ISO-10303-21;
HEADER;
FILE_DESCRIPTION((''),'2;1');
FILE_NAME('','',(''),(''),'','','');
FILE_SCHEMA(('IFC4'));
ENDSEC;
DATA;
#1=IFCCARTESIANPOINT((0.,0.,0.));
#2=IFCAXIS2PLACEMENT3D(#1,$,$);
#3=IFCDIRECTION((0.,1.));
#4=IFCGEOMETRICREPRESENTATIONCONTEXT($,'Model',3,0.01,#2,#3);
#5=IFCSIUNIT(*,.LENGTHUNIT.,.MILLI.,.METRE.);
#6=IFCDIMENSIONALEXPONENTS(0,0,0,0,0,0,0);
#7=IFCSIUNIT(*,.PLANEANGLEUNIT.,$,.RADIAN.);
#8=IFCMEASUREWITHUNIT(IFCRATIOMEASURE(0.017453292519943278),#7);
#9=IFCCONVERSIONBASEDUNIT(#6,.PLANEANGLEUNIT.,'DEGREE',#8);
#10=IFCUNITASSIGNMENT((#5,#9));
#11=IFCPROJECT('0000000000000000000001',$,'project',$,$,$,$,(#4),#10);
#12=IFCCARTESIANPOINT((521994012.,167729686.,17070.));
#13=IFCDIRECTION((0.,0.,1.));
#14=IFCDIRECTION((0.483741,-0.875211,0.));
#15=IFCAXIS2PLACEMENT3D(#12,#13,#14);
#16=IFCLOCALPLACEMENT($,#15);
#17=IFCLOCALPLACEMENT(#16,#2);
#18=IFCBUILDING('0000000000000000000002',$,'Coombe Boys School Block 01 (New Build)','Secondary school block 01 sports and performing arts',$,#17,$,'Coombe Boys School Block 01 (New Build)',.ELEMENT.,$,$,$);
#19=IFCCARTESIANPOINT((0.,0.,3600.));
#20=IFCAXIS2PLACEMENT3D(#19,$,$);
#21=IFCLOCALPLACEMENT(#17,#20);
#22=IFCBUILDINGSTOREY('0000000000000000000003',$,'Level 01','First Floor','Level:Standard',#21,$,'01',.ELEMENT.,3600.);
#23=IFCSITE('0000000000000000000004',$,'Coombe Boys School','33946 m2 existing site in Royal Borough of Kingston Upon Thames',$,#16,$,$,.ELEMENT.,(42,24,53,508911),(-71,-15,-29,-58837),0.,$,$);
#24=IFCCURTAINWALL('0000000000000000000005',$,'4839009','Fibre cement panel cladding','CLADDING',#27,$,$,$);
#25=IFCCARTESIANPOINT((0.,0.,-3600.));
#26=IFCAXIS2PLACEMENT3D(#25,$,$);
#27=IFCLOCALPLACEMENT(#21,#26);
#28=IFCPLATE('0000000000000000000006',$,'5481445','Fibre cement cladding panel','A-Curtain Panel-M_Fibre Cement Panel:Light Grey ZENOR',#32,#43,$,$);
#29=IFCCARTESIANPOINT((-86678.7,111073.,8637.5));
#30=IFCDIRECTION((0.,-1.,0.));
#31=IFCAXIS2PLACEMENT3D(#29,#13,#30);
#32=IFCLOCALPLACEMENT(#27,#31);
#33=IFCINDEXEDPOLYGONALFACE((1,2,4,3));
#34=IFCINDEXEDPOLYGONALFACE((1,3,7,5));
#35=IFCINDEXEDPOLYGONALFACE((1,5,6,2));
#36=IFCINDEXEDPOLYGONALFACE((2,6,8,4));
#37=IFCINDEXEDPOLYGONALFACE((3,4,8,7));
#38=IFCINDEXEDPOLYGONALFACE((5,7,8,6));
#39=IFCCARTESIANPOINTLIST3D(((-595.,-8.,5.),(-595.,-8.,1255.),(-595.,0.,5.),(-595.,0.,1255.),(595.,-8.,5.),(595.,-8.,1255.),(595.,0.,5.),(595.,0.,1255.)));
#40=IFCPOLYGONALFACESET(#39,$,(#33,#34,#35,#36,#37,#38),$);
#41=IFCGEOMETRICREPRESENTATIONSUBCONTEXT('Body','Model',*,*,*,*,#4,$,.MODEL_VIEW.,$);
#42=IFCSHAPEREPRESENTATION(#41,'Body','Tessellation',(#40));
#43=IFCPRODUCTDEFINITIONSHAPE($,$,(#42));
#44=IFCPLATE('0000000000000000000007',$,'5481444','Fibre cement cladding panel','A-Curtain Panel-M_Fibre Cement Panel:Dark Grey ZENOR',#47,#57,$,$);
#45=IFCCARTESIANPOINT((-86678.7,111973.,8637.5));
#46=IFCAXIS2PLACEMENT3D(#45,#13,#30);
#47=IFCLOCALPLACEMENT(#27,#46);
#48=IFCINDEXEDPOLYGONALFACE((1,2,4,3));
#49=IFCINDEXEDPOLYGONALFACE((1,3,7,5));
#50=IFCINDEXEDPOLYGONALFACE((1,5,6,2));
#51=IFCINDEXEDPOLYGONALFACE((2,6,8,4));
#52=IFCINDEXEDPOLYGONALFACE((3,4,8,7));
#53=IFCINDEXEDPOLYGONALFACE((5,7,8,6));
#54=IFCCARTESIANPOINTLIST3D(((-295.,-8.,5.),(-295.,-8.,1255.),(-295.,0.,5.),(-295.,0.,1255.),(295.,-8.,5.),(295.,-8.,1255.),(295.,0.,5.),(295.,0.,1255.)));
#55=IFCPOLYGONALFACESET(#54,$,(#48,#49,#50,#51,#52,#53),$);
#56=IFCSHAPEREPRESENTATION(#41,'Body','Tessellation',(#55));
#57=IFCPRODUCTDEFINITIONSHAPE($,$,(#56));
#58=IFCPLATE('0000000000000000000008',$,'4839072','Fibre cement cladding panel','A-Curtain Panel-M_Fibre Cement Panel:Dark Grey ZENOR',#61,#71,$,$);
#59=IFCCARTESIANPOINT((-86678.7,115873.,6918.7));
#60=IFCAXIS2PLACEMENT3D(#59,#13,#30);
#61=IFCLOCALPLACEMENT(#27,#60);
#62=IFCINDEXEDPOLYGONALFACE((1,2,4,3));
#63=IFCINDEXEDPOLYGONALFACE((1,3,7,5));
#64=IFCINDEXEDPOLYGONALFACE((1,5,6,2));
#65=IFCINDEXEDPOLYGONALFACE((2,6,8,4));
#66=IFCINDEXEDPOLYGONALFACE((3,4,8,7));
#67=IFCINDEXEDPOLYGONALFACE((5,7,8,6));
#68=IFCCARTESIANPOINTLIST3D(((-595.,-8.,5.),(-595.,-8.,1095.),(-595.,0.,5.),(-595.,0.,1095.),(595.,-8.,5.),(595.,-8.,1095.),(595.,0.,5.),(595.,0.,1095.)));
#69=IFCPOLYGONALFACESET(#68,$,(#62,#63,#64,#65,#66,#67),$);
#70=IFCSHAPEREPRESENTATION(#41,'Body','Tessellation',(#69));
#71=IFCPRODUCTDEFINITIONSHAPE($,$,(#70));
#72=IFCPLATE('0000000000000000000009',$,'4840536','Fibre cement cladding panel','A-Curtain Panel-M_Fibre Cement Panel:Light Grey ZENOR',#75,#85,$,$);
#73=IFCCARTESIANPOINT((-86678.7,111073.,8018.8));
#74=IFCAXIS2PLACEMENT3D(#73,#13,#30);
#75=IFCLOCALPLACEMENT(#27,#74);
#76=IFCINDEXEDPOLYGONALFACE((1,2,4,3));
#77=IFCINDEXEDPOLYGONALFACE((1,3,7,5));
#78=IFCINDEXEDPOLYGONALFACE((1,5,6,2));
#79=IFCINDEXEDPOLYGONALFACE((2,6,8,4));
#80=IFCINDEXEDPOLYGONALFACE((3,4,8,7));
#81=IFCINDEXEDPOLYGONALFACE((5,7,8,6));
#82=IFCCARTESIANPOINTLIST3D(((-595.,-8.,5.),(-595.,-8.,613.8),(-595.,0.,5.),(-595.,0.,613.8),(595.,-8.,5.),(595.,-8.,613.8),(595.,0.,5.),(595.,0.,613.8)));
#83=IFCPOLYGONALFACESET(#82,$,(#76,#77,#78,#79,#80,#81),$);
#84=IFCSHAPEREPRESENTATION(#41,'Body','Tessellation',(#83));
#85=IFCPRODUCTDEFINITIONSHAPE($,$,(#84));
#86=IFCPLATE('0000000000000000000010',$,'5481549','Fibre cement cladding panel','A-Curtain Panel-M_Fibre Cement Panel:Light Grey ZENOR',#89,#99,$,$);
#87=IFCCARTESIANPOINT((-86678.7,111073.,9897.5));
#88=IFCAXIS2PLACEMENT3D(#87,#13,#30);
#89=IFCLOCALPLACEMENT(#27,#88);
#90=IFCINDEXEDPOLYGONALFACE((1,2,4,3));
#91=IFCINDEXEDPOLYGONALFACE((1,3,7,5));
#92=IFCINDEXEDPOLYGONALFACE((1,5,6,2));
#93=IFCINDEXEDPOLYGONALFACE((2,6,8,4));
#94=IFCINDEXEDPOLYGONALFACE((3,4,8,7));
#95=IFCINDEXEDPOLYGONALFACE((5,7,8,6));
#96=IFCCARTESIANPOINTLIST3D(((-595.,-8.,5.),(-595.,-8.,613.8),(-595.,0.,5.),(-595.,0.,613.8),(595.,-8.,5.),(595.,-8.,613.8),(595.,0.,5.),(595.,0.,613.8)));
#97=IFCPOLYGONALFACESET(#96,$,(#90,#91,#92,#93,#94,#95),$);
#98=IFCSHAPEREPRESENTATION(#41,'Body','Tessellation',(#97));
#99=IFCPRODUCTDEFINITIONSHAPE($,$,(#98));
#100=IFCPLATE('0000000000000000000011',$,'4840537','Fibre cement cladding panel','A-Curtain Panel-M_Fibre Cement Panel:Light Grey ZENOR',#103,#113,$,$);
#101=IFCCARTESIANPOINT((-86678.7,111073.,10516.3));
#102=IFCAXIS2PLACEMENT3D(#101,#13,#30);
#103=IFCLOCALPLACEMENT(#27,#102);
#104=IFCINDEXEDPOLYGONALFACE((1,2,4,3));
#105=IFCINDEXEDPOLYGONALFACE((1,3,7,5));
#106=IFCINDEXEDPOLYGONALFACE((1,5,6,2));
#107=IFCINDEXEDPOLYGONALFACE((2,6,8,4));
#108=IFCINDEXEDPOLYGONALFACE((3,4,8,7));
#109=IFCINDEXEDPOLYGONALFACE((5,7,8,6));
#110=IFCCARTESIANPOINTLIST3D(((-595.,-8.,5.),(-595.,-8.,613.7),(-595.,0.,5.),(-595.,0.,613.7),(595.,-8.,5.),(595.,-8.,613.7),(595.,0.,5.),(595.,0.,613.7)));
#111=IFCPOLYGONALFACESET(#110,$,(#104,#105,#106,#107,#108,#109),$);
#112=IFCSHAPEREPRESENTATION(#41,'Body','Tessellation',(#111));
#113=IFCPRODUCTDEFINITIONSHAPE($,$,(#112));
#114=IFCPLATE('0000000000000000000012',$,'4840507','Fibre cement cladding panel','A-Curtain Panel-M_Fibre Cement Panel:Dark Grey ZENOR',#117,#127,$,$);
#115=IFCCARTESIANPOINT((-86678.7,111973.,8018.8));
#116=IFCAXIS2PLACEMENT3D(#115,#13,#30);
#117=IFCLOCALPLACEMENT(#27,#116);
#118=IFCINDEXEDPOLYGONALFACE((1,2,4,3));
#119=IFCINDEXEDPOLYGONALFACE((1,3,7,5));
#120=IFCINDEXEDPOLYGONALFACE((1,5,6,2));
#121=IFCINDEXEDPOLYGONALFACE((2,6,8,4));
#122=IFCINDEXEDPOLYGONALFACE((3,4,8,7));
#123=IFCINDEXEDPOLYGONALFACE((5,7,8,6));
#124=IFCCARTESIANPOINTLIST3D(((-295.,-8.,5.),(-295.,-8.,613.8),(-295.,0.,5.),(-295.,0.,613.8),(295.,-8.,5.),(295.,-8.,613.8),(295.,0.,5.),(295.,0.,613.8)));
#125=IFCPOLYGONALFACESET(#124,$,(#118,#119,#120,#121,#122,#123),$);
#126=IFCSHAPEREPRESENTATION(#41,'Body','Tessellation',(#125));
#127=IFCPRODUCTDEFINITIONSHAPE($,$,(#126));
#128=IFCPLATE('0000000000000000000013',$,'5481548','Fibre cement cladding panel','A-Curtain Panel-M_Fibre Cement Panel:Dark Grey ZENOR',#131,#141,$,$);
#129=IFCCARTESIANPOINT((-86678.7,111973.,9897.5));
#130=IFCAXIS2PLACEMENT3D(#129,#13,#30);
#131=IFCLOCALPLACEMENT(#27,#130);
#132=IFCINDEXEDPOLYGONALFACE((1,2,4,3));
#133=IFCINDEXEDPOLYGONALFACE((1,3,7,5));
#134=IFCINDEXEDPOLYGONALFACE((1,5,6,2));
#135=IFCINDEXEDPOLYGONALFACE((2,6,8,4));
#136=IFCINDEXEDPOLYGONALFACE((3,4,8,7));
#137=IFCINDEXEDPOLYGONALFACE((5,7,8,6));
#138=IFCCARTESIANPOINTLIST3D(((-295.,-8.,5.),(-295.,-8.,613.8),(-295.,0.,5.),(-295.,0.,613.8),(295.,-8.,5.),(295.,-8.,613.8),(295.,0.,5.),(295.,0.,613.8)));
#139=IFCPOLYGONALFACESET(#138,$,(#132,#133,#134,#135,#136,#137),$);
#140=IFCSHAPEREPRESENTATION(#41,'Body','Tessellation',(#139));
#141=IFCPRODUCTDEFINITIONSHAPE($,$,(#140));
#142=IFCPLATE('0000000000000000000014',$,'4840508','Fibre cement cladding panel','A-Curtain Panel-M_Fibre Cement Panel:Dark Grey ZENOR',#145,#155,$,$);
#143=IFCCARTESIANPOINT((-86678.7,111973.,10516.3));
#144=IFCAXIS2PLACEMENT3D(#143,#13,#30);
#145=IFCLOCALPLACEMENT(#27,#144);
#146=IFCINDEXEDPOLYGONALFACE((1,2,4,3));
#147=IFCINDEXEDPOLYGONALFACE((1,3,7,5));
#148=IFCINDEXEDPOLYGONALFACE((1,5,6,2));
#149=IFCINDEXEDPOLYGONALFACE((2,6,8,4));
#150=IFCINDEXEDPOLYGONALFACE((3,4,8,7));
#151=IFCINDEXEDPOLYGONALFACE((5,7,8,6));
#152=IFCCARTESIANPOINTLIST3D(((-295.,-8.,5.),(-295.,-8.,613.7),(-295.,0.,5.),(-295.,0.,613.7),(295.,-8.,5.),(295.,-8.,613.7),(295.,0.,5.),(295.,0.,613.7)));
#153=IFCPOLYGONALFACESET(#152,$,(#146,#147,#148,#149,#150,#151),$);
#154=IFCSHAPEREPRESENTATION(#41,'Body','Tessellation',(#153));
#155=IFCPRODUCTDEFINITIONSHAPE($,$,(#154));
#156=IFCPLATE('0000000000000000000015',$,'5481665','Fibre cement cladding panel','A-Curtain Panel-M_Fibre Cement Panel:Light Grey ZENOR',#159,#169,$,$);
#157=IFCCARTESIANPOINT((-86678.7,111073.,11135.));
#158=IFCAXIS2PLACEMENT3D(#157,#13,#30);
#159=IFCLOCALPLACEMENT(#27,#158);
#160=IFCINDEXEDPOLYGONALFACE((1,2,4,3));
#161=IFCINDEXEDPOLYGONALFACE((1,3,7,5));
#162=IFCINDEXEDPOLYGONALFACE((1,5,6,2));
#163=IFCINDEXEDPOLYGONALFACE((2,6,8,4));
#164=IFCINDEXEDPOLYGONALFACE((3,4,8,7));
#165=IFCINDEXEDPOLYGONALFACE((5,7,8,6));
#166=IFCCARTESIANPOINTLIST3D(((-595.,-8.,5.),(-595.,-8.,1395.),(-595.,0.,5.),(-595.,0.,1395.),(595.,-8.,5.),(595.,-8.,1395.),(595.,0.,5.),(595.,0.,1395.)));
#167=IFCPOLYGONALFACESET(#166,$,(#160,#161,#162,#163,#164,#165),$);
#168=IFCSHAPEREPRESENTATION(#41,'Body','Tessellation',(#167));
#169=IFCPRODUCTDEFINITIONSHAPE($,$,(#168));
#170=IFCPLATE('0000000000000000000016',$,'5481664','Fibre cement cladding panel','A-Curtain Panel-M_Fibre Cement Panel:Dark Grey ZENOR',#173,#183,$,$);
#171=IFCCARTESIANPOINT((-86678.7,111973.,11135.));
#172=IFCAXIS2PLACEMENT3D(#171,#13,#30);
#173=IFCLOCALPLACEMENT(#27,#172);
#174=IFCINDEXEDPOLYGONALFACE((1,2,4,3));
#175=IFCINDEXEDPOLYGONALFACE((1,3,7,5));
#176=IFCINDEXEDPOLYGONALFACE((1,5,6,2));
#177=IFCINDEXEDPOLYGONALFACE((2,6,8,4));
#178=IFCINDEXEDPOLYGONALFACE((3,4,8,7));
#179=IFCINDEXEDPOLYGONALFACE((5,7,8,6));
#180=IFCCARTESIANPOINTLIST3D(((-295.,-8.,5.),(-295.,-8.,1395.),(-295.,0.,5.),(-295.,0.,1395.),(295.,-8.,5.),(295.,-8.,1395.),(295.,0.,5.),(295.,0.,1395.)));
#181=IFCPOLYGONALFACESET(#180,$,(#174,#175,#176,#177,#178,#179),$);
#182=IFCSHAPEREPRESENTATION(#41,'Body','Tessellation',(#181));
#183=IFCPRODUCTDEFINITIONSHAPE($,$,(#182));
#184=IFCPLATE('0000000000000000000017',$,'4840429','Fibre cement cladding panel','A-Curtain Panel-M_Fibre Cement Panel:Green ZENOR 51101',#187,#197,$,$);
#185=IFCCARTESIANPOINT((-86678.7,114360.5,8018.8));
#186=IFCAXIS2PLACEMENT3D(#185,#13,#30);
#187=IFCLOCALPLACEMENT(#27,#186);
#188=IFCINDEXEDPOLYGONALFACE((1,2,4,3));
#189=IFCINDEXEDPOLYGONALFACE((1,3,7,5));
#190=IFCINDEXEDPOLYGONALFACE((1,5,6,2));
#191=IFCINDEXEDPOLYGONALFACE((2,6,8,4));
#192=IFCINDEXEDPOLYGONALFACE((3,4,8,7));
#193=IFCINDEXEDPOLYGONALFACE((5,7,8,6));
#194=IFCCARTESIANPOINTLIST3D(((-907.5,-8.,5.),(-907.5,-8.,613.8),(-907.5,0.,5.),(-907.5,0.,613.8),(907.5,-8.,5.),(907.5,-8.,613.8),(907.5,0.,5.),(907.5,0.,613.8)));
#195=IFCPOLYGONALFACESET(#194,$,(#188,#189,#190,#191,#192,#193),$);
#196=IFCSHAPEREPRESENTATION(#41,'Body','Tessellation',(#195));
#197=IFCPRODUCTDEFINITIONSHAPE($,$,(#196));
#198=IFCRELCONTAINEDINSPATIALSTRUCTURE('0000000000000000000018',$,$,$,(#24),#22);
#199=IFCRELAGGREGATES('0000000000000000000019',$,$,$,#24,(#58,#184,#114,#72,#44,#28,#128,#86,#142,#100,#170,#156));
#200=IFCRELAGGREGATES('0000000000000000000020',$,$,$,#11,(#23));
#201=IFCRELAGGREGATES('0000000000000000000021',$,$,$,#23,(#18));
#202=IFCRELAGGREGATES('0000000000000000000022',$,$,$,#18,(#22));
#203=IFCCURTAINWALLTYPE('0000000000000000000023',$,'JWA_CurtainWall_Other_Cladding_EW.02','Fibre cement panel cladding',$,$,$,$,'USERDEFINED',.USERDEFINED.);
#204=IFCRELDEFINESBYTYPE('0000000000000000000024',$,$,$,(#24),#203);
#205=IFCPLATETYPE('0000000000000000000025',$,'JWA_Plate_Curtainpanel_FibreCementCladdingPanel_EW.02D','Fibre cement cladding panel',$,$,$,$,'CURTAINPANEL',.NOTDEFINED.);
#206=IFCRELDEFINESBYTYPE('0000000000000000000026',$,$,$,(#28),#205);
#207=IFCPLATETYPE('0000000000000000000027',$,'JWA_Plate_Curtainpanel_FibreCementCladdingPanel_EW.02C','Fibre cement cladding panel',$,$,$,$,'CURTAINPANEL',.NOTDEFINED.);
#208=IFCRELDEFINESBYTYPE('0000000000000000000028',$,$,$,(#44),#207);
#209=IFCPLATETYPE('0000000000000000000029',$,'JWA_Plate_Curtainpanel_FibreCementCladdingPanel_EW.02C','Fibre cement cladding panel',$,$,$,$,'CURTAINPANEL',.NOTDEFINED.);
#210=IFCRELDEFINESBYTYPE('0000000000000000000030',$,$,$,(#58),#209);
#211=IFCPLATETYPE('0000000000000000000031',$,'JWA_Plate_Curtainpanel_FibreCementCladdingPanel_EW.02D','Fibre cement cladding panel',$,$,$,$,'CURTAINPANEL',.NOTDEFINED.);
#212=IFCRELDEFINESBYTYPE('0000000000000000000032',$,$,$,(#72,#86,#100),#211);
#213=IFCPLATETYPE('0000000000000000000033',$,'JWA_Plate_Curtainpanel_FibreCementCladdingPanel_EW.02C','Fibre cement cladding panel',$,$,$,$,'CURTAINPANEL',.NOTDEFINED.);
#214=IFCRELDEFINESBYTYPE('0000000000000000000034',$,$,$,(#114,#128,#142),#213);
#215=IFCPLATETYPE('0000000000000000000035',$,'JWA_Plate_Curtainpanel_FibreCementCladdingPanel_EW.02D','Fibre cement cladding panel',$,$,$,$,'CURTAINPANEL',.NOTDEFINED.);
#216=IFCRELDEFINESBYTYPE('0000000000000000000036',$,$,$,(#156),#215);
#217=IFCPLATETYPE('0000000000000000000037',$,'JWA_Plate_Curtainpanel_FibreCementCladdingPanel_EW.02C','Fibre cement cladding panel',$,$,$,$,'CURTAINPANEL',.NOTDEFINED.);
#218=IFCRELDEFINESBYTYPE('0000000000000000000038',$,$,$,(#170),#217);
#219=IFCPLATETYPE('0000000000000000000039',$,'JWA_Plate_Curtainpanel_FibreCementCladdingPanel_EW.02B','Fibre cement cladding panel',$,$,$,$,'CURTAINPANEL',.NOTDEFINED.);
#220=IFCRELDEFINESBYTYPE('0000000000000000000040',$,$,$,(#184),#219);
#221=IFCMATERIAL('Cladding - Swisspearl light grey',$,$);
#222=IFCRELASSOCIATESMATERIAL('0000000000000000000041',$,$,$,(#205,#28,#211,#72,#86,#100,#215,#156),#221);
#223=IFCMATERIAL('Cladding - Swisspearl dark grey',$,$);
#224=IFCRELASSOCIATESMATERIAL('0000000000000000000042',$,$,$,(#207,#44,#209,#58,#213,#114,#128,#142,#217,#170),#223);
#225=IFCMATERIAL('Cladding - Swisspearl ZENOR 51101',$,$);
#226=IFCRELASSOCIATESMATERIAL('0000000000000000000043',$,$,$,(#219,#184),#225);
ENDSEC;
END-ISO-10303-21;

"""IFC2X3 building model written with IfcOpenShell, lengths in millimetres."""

from ifc_helpers import new_model, entity, si_unit, converted_unit, direction, frame, origin, origin_2d_with_axis, place, context, subcontext, project, spatial, rectangle, extrude, source, transform, mapped, material, type_object, type_shapes, element, aggregate, save


model = new_model("IFC2X3")

# Units and contexts
model_context = context("Model", 3, precision=0.01, world=origin(), true_north=direction((0.0, 1.0)))
body_context = subcontext(model_context, "Body", "Model", "MODEL_VIEW")
ifc_project = project(units=[si_unit("LENGTHUNIT", "METRE", prefix="MILLI"), converted_unit("PLANEANGLEUNIT", "DEGREE", entity("IfcRatioMeasure", 0.017453292519943278), si_unit("PLANEANGLEUNIT", "RADIAN"), dimensions=[0, 0, 0, 0, 0, 0, 0])], contexts=[model_context])

# Site, building, storey
site_placement = place(None, frame((521994012.0, 167729686.0, 17070.0), z_axis=(0.0, 0.0, 1.0), x_axis=(0.483741, -0.875211, 0.0)))
site = spatial("IfcSite", under=ifc_project, at=site_placement, Name="Coombe Boys School", Description="33946 m2 existing site in Royal Borough of Kingston Upon Thames", CompositionType="ELEMENT", RefLatitude=(42, 24, 53, 508911), RefLongitude=(-71, -15, -29, -58837), RefElevation=0.0)
building_placement = place(site_placement, origin())
building = spatial("IfcBuilding", under=site, at=building_placement, Name="Coombe Boys School Block 01 (New Build)", Description="Secondary school block 01 sports and performing arts", LongName="Coombe Boys School Block 01 (New Build)", CompositionType="ELEMENT")
storey_placement = place(building_placement, frame((0.0, 0.0, 3600.0)))
storey = spatial("IfcBuildingStorey", under=building, at=storey_placement, Name="Level 01", Description="First Floor", ObjectType="Level:Standard", LongName="01", CompositionType="ELEMENT", Elevation=3600.0)

# Curtain wall, plates
curtain_wall_type = type_object("IfcCurtainWallType", Name="JWA_CurtainWall_Other_Cladding_EW.02", Description="Fibre cement panel cladding", ElementType="USERDEFINED", PredefinedType="USERDEFINED")
curtain_wall_placement = place(storey_placement, frame((0.0, 0.0, -3600.0)))
curtain_wall = element("IfcCurtainWall", 1, at=curtain_wall_placement, inside=storey, type_object=curtain_wall_type, Name="4839009", Description="Fibre cement panel cladding", ObjectType="CLADDING")
ifc_material_1 = material(Name="Cladding - Swisspearl light grey")
plate_type_1 = type_object("IfcPlateType", Name="JWA_Plate_Curtainpanel_FibreCementCladdingPanel_EW.02D", Description="Fibre cement cladding panel", ElementType="CURTAINPANEL", PredefinedType="NOTDEFINED", material=ifc_material_1)
shared_shape_1 = source(origin(), body_context, "Body", "SweptSolid", [
    extrude(rectangle(XDim=1190.0, YDim=8.0, at=origin_2d_with_axis()), frame((0.0, -4.0, 5.0), z_axis=(0.0, 0.0, 1.0), x_axis=(-1.0, 0.0, 0.0)), (0.0, 0.0, 1.0), 1250.0),
])
type_shapes(plate_type_1, [shared_shape_1])
plate_1_placement = place(curtain_wall_placement, frame((-86678.7, 111073.0, 8637.5), z_axis=(0.0, 0.0, 1.0), x_axis=(0.0, -1.0, 0.0)))
plate_1 = element("IfcPlate", 2, at=plate_1_placement, type_object=plate_type_1, material=ifc_material_1, Name="5481445", Description="Fibre cement cladding panel", ObjectType="A-Curtain Panel-M_Fibre Cement Panel:Light Grey ZENOR", context=body_context, shape_type="MappedRepresentation", body=[
    mapped(shared_shape_1, transform((0.0, 0.0, 0.0), scale=1.0)),
])
ifc_material_2 = material(Name="Cladding - Swisspearl dark grey")
plate_type_2 = type_object("IfcPlateType", Name="JWA_Plate_Curtainpanel_FibreCementCladdingPanel_EW.02C", Description="Fibre cement cladding panel", ElementType="CURTAINPANEL", PredefinedType="NOTDEFINED", material=ifc_material_2)
shared_shape_2 = source(origin(), body_context, "Body", "SweptSolid", [
    extrude(rectangle(XDim=590.0, YDim=8.0, at=origin_2d_with_axis()), frame((0.0, -4.0, 5.0), z_axis=(0.0, 0.0, 1.0), x_axis=(-1.0, 0.0, 0.0)), (0.0, 0.0, 1.0), 1250.0),
])
type_shapes(plate_type_2, [shared_shape_2])
plate_2_placement = place(curtain_wall_placement, frame((-86678.7, 111973.0, 8637.5), z_axis=(0.0, 0.0, 1.0), x_axis=(0.0, -1.0, 0.0)))
plate_2 = element("IfcPlate", 3, at=plate_2_placement, type_object=plate_type_2, material=ifc_material_2, Name="5481444", Description="Fibre cement cladding panel", ObjectType="A-Curtain Panel-M_Fibre Cement Panel:Dark Grey ZENOR", context=body_context, shape_type="MappedRepresentation", body=[
    mapped(shared_shape_2, transform((0.0, 0.0, 0.0), scale=1.0)),
])
plate_type_3 = type_object("IfcPlateType", Name="JWA_Plate_Curtainpanel_FibreCementCladdingPanel_EW.02C", Description="Fibre cement cladding panel", ElementType="CURTAINPANEL", PredefinedType="NOTDEFINED", material=ifc_material_2)
shared_shape_3 = source(origin(), body_context, "Body", "SweptSolid", [
    extrude(rectangle(XDim=1190.0, YDim=8.0, at=origin_2d_with_axis()), frame((0.0, -4.0, 5.0), z_axis=(0.0, 0.0, 1.0), x_axis=(-1.0, 0.0, 0.0)), (0.0, 0.0, 1.0), 1090.0),
])
type_shapes(plate_type_3, [shared_shape_3])
plate_3_placement = place(curtain_wall_placement, frame((-86678.7, 115873.0, 6918.7), z_axis=(0.0, 0.0, 1.0), x_axis=(0.0, -1.0, 0.0)))
plate_3 = element("IfcPlate", 4, at=plate_3_placement, type_object=plate_type_3, material=ifc_material_2, Name="4839072", Description="Fibre cement cladding panel", ObjectType="A-Curtain Panel-M_Fibre Cement Panel:Dark Grey ZENOR", context=body_context, shape_type="MappedRepresentation", body=[
    mapped(shared_shape_3, transform((0.0, 0.0, 0.0), scale=1.0)),
])
plate_type_4 = type_object("IfcPlateType", Name="JWA_Plate_Curtainpanel_FibreCementCladdingPanel_EW.02D", Description="Fibre cement cladding panel", ElementType="CURTAINPANEL", PredefinedType="NOTDEFINED", material=ifc_material_1)
shared_shape_4 = source(origin(), body_context, "Body", "SweptSolid", [
    extrude(rectangle(XDim=1190.0, YDim=8.0, at=origin_2d_with_axis()), frame((0.0, -4.0, 5.0), z_axis=(0.0, 0.0, 1.0), x_axis=(-1.0, 0.0, 0.0)), (0.0, 0.0, 1.0), 608.8),
])
type_shapes(plate_type_4, [shared_shape_4])
plate_4_placement = place(curtain_wall_placement, frame((-86678.7, 111073.0, 8018.8), z_axis=(0.0, 0.0, 1.0), x_axis=(0.0, -1.0, 0.0)))
plate_4 = element("IfcPlate", 5, at=plate_4_placement, type_object=plate_type_4, material=ifc_material_1, Name="4840536", Description="Fibre cement cladding panel", ObjectType="A-Curtain Panel-M_Fibre Cement Panel:Light Grey ZENOR", context=body_context, shape_type="MappedRepresentation", body=[
    mapped(shared_shape_4, transform((0.0, 0.0, 0.0), scale=1.0)),
])
plate_5_placement = place(curtain_wall_placement, frame((-86678.7, 111073.0, 9897.5), z_axis=(0.0, 0.0, 1.0), x_axis=(0.0, -1.0, 0.0)))
plate_5 = element("IfcPlate", 6, at=plate_5_placement, type_object=plate_type_4, material=ifc_material_1, Name="5481549", Description="Fibre cement cladding panel", ObjectType="A-Curtain Panel-M_Fibre Cement Panel:Light Grey ZENOR", context=body_context, shape_type="MappedRepresentation", body=[
    mapped(shared_shape_4, transform((0.0, 0.0, 0.0), scale=1.0)),
])
plate_6_placement = place(curtain_wall_placement, frame((-86678.7, 111073.0, 10516.3), z_axis=(0.0, 0.0, 1.0), x_axis=(0.0, -1.0, 0.0)))
plate_6 = element("IfcPlate", 7, at=plate_6_placement, type_object=plate_type_4, material=ifc_material_1, Name="4840537", Description="Fibre cement cladding panel", ObjectType="A-Curtain Panel-M_Fibre Cement Panel:Light Grey ZENOR", context=body_context, shape_type="MappedRepresentation", body=[
    mapped(shared_shape_4, transform((0.0, 0.0, 0.0), scale=1.0)),
])
plate_type_5 = type_object("IfcPlateType", Name="JWA_Plate_Curtainpanel_FibreCementCladdingPanel_EW.02C", Description="Fibre cement cladding panel", ElementType="CURTAINPANEL", PredefinedType="NOTDEFINED", material=ifc_material_2)
shared_shape_5 = source(origin(), body_context, "Body", "SweptSolid", [
    extrude(rectangle(XDim=590.0, YDim=8.0, at=origin_2d_with_axis()), frame((0.0, -4.0, 5.0), z_axis=(0.0, 0.0, 1.0), x_axis=(-1.0, 0.0, 0.0)), (0.0, 0.0, 1.0), 608.8),
])
type_shapes(plate_type_5, [shared_shape_5])
plate_7_placement = place(curtain_wall_placement, frame((-86678.7, 111973.0, 8018.8), z_axis=(0.0, 0.0, 1.0), x_axis=(0.0, -1.0, 0.0)))
plate_7 = element("IfcPlate", 8, at=plate_7_placement, type_object=plate_type_5, material=ifc_material_2, Name="4840507", Description="Fibre cement cladding panel", ObjectType="A-Curtain Panel-M_Fibre Cement Panel:Dark Grey ZENOR", context=body_context, shape_type="MappedRepresentation", body=[
    mapped(shared_shape_5, transform((0.0, 0.0, 0.0), scale=1.0)),
])
plate_8_placement = place(curtain_wall_placement, frame((-86678.7, 111973.0, 9897.5), z_axis=(0.0, 0.0, 1.0), x_axis=(0.0, -1.0, 0.0)))
plate_8 = element("IfcPlate", 9, at=plate_8_placement, type_object=plate_type_5, material=ifc_material_2, Name="5481548", Description="Fibre cement cladding panel", ObjectType="A-Curtain Panel-M_Fibre Cement Panel:Dark Grey ZENOR", context=body_context, shape_type="MappedRepresentation", body=[
    mapped(shared_shape_5, transform((0.0, 0.0, 0.0), scale=1.0)),
])
plate_9_placement = place(curtain_wall_placement, frame((-86678.7, 111973.0, 10516.3), z_axis=(0.0, 0.0, 1.0), x_axis=(0.0, -1.0, 0.0)))
plate_9 = element("IfcPlate", 10, at=plate_9_placement, type_object=plate_type_5, material=ifc_material_2, Name="4840508", Description="Fibre cement cladding panel", ObjectType="A-Curtain Panel-M_Fibre Cement Panel:Dark Grey ZENOR", context=body_context, shape_type="MappedRepresentation", body=[
    mapped(shared_shape_5, transform((0.0, 0.0, 0.0), scale=1.0)),
])
plate_type_6 = type_object("IfcPlateType", Name="JWA_Plate_Curtainpanel_FibreCementCladdingPanel_EW.02D", Description="Fibre cement cladding panel", ElementType="CURTAINPANEL", PredefinedType="NOTDEFINED", material=ifc_material_1)
shared_shape_6 = source(origin(), body_context, "Body", "SweptSolid", [
    extrude(rectangle(XDim=1190.0, YDim=8.0, at=origin_2d_with_axis()), frame((0.0, -4.0, 5.0), z_axis=(0.0, 0.0, 1.0), x_axis=(-1.0, 0.0, 0.0)), (0.0, 0.0, 1.0), 1390.0),
])
type_shapes(plate_type_6, [shared_shape_6])
plate_10_placement = place(curtain_wall_placement, frame((-86678.7, 111073.0, 11135.0), z_axis=(0.0, 0.0, 1.0), x_axis=(0.0, -1.0, 0.0)))
plate_10 = element("IfcPlate", 11, at=plate_10_placement, type_object=plate_type_6, material=ifc_material_1, Name="5481665", Description="Fibre cement cladding panel", ObjectType="A-Curtain Panel-M_Fibre Cement Panel:Light Grey ZENOR", context=body_context, shape_type="MappedRepresentation", body=[
    mapped(shared_shape_6, transform((0.0, 0.0, 0.0), scale=1.0)),
])
plate_type_7 = type_object("IfcPlateType", Name="JWA_Plate_Curtainpanel_FibreCementCladdingPanel_EW.02C", Description="Fibre cement cladding panel", ElementType="CURTAINPANEL", PredefinedType="NOTDEFINED", material=ifc_material_2)
shared_shape_7 = source(origin(), body_context, "Body", "SweptSolid", [
    extrude(rectangle(XDim=590.0, YDim=8.0, at=origin_2d_with_axis()), frame((0.0, -4.0, 5.0), z_axis=(0.0, 0.0, 1.0), x_axis=(-1.0, 0.0, 0.0)), (0.0, 0.0, 1.0), 1390.0),
])
type_shapes(plate_type_7, [shared_shape_7])
plate_11_placement = place(curtain_wall_placement, frame((-86678.7, 111973.0, 11135.0), z_axis=(0.0, 0.0, 1.0), x_axis=(0.0, -1.0, 0.0)))
plate_11 = element("IfcPlate", 12, at=plate_11_placement, type_object=plate_type_7, material=ifc_material_2, Name="5481664", Description="Fibre cement cladding panel", ObjectType="A-Curtain Panel-M_Fibre Cement Panel:Dark Grey ZENOR", context=body_context, shape_type="MappedRepresentation", body=[
    mapped(shared_shape_7, transform((0.0, 0.0, 0.0), scale=1.0)),
])
ifc_material_3 = material(Name="Cladding - Swisspearl ZENOR 51101")
plate_type_8 = type_object("IfcPlateType", Name="JWA_Plate_Curtainpanel_FibreCementCladdingPanel_EW.02B", Description="Fibre cement cladding panel", ElementType="CURTAINPANEL", PredefinedType="NOTDEFINED", material=ifc_material_3)
shared_shape_8 = source(origin(), body_context, "Body", "SweptSolid", [
    extrude(rectangle(XDim=1815.0, YDim=8.0, at=origin_2d_with_axis()), frame((0.0, -4.0, 5.0), z_axis=(0.0, 0.0, 1.0), x_axis=(-1.0, 0.0, 0.0)), (0.0, 0.0, 1.0), 608.8),
])
type_shapes(plate_type_8, [shared_shape_8])
plate_12_placement = place(curtain_wall_placement, frame((-86678.7, 114360.5, 8018.8), z_axis=(0.0, 0.0, 1.0), x_axis=(0.0, -1.0, 0.0)))
plate_12 = element("IfcPlate", 13, at=plate_12_placement, type_object=plate_type_8, material=ifc_material_3, Name="4840429", Description="Fibre cement cladding panel", ObjectType="A-Curtain Panel-M_Fibre Cement Panel:Green ZENOR 51101", context=body_context, shape_type="MappedRepresentation", body=[
    mapped(shared_shape_8, transform((0.0, 0.0, 0.0), scale=1.0)),
])
aggregate(curtain_wall, [plate_3, plate_12, plate_7, plate_4, plate_2, plate_1, plate_8, plate_5, plate_9, plate_6, plate_11, plate_10])

save(model, "model.ifc")
